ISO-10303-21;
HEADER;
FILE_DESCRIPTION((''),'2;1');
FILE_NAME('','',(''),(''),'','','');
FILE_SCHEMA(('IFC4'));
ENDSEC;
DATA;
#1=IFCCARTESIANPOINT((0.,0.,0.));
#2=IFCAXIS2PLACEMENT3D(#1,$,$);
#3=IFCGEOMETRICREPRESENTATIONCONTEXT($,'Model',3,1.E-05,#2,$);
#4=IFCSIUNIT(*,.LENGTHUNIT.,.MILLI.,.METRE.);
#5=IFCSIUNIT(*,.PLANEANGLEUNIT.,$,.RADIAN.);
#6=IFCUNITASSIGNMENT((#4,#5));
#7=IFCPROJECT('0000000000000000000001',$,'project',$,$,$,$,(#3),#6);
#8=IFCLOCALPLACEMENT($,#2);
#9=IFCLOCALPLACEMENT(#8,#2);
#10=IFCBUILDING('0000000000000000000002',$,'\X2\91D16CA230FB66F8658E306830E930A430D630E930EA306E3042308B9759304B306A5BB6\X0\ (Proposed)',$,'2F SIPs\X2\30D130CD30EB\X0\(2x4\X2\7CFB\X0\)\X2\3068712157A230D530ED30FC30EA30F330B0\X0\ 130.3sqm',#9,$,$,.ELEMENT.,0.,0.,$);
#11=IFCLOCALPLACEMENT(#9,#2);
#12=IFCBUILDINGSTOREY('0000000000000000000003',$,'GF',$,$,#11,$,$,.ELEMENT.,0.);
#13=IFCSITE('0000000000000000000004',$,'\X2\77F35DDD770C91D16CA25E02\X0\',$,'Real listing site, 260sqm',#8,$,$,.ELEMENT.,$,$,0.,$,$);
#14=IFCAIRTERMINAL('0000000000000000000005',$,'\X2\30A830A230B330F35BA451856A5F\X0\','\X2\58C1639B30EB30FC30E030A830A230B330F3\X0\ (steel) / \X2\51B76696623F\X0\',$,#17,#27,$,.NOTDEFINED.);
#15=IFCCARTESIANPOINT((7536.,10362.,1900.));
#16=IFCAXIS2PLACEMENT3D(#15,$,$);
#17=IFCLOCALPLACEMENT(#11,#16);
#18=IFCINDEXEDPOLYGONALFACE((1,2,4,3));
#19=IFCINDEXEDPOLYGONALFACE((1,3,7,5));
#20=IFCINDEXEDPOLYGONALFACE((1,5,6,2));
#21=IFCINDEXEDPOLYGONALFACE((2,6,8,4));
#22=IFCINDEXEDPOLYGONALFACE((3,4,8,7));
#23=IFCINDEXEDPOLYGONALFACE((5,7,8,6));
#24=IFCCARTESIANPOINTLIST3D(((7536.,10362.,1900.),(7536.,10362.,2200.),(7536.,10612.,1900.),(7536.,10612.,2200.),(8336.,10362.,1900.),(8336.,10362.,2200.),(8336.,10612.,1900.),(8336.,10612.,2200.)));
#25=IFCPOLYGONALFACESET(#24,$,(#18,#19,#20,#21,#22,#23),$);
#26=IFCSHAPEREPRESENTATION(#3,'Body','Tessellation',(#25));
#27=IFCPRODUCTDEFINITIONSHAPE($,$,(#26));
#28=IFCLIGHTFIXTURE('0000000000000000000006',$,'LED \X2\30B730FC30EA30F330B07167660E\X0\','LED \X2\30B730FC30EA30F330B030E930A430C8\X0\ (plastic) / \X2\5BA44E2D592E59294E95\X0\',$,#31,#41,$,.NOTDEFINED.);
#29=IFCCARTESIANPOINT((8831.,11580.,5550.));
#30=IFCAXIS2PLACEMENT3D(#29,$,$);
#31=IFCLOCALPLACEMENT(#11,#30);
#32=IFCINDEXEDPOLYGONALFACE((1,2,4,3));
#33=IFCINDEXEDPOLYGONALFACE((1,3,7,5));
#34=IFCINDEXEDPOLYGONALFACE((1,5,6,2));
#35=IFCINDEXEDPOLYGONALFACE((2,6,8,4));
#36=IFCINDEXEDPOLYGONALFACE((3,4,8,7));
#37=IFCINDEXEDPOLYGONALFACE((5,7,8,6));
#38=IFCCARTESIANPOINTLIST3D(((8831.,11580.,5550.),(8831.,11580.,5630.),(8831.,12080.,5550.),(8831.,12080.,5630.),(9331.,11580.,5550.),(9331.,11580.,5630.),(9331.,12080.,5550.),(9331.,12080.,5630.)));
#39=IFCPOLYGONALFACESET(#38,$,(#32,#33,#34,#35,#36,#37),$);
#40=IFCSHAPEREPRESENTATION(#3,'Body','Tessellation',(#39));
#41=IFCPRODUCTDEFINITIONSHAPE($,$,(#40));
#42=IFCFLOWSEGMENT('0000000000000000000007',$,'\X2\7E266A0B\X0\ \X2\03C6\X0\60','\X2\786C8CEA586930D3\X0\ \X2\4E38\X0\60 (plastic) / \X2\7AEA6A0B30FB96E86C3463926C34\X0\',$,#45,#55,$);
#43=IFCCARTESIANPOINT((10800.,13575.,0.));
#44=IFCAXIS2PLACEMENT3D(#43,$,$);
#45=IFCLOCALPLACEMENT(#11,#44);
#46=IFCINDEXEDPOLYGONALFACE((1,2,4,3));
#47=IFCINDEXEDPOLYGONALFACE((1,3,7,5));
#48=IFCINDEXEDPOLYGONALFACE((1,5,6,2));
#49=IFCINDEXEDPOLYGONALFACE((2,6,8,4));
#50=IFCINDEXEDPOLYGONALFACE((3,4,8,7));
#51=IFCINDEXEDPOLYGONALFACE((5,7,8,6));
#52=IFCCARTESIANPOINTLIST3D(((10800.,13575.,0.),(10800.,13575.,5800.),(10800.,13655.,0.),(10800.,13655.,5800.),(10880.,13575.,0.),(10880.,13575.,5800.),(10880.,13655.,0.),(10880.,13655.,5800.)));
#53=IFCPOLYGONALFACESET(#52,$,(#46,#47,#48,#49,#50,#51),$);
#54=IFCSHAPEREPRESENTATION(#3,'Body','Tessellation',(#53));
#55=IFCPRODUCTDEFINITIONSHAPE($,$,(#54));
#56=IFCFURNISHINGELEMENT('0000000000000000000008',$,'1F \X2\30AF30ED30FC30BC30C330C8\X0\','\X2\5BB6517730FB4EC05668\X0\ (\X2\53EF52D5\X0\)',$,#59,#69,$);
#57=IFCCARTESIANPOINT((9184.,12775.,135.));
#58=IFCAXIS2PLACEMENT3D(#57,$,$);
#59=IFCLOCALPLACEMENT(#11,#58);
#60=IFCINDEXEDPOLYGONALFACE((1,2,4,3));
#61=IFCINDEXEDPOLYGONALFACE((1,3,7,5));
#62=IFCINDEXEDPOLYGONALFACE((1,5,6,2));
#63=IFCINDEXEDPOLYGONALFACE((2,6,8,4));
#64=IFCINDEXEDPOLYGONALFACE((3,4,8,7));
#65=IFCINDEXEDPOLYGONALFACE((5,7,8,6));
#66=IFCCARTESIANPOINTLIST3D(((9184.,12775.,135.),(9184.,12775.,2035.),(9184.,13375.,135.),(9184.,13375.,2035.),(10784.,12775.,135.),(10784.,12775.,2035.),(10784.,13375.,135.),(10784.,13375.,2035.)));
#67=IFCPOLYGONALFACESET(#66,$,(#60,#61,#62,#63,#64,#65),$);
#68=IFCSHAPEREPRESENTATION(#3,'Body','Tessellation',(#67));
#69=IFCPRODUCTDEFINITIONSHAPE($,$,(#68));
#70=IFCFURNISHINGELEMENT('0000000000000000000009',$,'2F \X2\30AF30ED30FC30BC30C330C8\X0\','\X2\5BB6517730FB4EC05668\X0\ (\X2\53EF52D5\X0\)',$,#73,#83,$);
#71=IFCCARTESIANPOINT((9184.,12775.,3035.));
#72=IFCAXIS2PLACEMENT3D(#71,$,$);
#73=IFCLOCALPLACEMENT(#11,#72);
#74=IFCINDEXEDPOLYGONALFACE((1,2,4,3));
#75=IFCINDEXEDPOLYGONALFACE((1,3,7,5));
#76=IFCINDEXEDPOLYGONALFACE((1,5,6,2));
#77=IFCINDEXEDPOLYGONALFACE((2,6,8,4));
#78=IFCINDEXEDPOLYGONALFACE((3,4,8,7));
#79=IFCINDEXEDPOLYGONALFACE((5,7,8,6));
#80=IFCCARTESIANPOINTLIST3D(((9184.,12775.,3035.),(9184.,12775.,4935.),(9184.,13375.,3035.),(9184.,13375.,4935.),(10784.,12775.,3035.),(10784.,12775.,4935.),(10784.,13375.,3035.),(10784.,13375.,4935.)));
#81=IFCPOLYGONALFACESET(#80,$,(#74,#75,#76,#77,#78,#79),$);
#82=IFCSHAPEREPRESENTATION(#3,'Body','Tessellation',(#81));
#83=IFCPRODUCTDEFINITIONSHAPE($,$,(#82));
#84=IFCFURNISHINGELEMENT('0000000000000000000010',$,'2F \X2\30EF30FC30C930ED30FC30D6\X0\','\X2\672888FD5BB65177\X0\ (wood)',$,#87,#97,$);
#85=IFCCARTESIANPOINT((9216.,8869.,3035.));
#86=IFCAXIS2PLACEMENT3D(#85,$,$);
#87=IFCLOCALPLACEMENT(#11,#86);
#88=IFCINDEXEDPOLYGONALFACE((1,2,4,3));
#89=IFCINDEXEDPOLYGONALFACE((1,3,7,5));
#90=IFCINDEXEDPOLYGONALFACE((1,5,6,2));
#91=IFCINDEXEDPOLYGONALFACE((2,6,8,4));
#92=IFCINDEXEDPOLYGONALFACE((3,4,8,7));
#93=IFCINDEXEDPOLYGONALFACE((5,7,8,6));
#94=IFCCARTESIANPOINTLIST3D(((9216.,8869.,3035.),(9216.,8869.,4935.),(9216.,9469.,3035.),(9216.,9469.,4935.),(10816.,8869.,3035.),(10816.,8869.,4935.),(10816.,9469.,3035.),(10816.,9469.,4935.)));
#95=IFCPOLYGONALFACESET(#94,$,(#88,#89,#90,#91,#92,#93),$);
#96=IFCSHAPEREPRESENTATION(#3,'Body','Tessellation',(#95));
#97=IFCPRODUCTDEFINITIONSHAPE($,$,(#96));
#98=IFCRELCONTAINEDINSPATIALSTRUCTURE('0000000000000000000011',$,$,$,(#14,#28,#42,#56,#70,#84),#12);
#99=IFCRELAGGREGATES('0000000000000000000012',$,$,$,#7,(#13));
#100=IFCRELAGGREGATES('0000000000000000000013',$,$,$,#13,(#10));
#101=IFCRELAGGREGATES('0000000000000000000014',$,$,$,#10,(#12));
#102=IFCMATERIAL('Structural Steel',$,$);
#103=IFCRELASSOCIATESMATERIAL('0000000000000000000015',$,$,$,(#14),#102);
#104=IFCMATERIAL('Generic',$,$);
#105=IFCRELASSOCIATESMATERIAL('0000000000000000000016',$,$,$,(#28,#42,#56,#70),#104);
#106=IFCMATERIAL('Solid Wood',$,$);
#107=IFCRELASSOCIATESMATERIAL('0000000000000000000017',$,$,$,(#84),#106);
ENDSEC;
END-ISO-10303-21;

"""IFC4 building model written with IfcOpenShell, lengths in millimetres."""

from ifc_helpers import new_model, si_unit, frame, frame_2d, origin, place, context, project, spatial, rectangle, extrude, material, element, save


model = new_model("IFC4")

# Units and contexts
model_context = context("Model", 3, precision=1e-05, world=origin())
ifc_project = project(units=[si_unit("LENGTHUNIT", "METRE", prefix="MILLI"), si_unit("PLANEANGLEUNIT", "RADIAN")], contexts=[model_context])

# Site, building, storey
site_placement = place(None, origin())
site = spatial("IfcSite", under=ifc_project, at=site_placement, Name="石川県金沢市", ObjectType="Real listing site, 260sqm", CompositionType="ELEMENT", RefElevation=0.0)
building_placement = place(site_placement, origin())
building = spatial("IfcBuilding", under=site, at=building_placement, Name="金沢・書斎とライブラリのある静かな家 (Proposed)", ObjectType="2F SIPsパネル(2x4系)と無垢フローリング 130.3sqm", CompositionType="ELEMENT", ElevationOfRefHeight=0.0, ElevationOfTerrain=0.0)
storey_placement = place(building_placement, origin())
storey = spatial("IfcBuildingStorey", under=building, at=storey_placement, Name="GF", CompositionType="ELEMENT", Elevation=0.0)

# Shared definitions
ifc_material_1 = material(Name="Solid Wood")

# Shared definitions
ifc_material_2 = material(Name="Structural Steel")

# Shared definitions
ifc_material_3 = material(Name="Generic")

# Air terminal
air_terminal_placement = place(storey_placement, frame((7536.0, 10362.0, 1900.0)))
element("IfcAirTerminal", 1, at=air_terminal_placement, inside=storey, material=ifc_material_2, Name="エアコン室内機", Description="壁掛ルームエアコン (steel) / 冷暖房", PredefinedType="NOTDEFINED", context=model_context, shape_type="SweptSolid", body=[
    extrude(rectangle(XDim=800.0, YDim=250.0, at=frame_2d((400.0, 125.0))), frame((7536.0, 10362.0, 1900.0)), (0.0, 0.0, 1.0), 300.0),
])

# Light fixture
light_fixture_1_placement = place(storey_placement, frame((8831.0, 11580.0, 5550.0)))
element("IfcLightFixture", 2, at=light_fixture_1_placement, inside=storey, material=ifc_material_3, Name="LED シーリング照明", Description="LED シーリングライト (plastic) / 室中央天井", PredefinedType="NOTDEFINED", context=model_context, shape_type="SweptSolid", body=[
    extrude(rectangle(XDim=500.0, YDim=500.0, at=frame_2d((250.0, 250.0))), frame((8831.0, 11580.0, 5550.0)), (0.0, 0.0, 1.0), 80.0),
])

# Flow segment
flow_segment_placement = place(storey_placement, frame((10800.0, 13575.0, 0.0)))
element("IfcFlowSegment", 3, at=flow_segment_placement, inside=storey, material=ifc_material_3, Name="縦樋 φ60", Description="硬質塩ビ 丸60 (plastic) / 竪樋・雨水排水", context=model_context, shape_type="SweptSolid", body=[
    extrude(rectangle(XDim=80.0, YDim=80.0, at=frame_2d((40.0, 40.0))), frame((10800.0, 13575.0, 0.0)), (0.0, 0.0, 1.0), 5800.0),
])

# Furnishing elements
furnishing_1_placement = place(storey_placement, frame((9184.0, 12775.0, 135.0)))
element("IfcFurnishingElement", 4, at=furnishing_1_placement, inside=storey, material=ifc_material_3, Name="1F クローゼット", Description="家具・什器 (可動)", context=model_context, shape_type="SweptSolid", body=[
    extrude(rectangle(XDim=1600.0, YDim=600.0, at=frame_2d((800.0, 300.0))), frame((9184.0, 12775.0, 135.0)), (0.0, 0.0, 1.0), 1900.0),
])
furnishing_2_placement = place(storey_placement, frame((9184.0, 12775.0, 3035.0)))
element("IfcFurnishingElement", 5, at=furnishing_2_placement, inside=storey, material=ifc_material_3, Name="2F クローゼット", Description="家具・什器 (可動)", context=model_context, shape_type="SweptSolid", body=[
    extrude(rectangle(XDim=1600.0, YDim=600.0, at=frame_2d((800.0, 300.0))), frame((9184.0, 12775.0, 3035.0)), (0.0, 0.0, 1.0), 1900.0),
])
furnishing_3_placement = place(storey_placement, frame((9216.0, 8869.0, 3035.0)))
element("IfcFurnishingElement", 6, at=furnishing_3_placement, inside=storey, material=ifc_material_1, Name="2F ワードローブ", Description="木製家具 (wood)", context=model_context, shape_type="SweptSolid", body=[
    extrude(rectangle(XDim=1600.0, YDim=600.0, at=frame_2d((800.0, 300.0))), frame((9216.0, 8869.0, 3035.0)), (0.0, 0.0, 1.0), 1900.0),
])

save(model, "model.ifc")
